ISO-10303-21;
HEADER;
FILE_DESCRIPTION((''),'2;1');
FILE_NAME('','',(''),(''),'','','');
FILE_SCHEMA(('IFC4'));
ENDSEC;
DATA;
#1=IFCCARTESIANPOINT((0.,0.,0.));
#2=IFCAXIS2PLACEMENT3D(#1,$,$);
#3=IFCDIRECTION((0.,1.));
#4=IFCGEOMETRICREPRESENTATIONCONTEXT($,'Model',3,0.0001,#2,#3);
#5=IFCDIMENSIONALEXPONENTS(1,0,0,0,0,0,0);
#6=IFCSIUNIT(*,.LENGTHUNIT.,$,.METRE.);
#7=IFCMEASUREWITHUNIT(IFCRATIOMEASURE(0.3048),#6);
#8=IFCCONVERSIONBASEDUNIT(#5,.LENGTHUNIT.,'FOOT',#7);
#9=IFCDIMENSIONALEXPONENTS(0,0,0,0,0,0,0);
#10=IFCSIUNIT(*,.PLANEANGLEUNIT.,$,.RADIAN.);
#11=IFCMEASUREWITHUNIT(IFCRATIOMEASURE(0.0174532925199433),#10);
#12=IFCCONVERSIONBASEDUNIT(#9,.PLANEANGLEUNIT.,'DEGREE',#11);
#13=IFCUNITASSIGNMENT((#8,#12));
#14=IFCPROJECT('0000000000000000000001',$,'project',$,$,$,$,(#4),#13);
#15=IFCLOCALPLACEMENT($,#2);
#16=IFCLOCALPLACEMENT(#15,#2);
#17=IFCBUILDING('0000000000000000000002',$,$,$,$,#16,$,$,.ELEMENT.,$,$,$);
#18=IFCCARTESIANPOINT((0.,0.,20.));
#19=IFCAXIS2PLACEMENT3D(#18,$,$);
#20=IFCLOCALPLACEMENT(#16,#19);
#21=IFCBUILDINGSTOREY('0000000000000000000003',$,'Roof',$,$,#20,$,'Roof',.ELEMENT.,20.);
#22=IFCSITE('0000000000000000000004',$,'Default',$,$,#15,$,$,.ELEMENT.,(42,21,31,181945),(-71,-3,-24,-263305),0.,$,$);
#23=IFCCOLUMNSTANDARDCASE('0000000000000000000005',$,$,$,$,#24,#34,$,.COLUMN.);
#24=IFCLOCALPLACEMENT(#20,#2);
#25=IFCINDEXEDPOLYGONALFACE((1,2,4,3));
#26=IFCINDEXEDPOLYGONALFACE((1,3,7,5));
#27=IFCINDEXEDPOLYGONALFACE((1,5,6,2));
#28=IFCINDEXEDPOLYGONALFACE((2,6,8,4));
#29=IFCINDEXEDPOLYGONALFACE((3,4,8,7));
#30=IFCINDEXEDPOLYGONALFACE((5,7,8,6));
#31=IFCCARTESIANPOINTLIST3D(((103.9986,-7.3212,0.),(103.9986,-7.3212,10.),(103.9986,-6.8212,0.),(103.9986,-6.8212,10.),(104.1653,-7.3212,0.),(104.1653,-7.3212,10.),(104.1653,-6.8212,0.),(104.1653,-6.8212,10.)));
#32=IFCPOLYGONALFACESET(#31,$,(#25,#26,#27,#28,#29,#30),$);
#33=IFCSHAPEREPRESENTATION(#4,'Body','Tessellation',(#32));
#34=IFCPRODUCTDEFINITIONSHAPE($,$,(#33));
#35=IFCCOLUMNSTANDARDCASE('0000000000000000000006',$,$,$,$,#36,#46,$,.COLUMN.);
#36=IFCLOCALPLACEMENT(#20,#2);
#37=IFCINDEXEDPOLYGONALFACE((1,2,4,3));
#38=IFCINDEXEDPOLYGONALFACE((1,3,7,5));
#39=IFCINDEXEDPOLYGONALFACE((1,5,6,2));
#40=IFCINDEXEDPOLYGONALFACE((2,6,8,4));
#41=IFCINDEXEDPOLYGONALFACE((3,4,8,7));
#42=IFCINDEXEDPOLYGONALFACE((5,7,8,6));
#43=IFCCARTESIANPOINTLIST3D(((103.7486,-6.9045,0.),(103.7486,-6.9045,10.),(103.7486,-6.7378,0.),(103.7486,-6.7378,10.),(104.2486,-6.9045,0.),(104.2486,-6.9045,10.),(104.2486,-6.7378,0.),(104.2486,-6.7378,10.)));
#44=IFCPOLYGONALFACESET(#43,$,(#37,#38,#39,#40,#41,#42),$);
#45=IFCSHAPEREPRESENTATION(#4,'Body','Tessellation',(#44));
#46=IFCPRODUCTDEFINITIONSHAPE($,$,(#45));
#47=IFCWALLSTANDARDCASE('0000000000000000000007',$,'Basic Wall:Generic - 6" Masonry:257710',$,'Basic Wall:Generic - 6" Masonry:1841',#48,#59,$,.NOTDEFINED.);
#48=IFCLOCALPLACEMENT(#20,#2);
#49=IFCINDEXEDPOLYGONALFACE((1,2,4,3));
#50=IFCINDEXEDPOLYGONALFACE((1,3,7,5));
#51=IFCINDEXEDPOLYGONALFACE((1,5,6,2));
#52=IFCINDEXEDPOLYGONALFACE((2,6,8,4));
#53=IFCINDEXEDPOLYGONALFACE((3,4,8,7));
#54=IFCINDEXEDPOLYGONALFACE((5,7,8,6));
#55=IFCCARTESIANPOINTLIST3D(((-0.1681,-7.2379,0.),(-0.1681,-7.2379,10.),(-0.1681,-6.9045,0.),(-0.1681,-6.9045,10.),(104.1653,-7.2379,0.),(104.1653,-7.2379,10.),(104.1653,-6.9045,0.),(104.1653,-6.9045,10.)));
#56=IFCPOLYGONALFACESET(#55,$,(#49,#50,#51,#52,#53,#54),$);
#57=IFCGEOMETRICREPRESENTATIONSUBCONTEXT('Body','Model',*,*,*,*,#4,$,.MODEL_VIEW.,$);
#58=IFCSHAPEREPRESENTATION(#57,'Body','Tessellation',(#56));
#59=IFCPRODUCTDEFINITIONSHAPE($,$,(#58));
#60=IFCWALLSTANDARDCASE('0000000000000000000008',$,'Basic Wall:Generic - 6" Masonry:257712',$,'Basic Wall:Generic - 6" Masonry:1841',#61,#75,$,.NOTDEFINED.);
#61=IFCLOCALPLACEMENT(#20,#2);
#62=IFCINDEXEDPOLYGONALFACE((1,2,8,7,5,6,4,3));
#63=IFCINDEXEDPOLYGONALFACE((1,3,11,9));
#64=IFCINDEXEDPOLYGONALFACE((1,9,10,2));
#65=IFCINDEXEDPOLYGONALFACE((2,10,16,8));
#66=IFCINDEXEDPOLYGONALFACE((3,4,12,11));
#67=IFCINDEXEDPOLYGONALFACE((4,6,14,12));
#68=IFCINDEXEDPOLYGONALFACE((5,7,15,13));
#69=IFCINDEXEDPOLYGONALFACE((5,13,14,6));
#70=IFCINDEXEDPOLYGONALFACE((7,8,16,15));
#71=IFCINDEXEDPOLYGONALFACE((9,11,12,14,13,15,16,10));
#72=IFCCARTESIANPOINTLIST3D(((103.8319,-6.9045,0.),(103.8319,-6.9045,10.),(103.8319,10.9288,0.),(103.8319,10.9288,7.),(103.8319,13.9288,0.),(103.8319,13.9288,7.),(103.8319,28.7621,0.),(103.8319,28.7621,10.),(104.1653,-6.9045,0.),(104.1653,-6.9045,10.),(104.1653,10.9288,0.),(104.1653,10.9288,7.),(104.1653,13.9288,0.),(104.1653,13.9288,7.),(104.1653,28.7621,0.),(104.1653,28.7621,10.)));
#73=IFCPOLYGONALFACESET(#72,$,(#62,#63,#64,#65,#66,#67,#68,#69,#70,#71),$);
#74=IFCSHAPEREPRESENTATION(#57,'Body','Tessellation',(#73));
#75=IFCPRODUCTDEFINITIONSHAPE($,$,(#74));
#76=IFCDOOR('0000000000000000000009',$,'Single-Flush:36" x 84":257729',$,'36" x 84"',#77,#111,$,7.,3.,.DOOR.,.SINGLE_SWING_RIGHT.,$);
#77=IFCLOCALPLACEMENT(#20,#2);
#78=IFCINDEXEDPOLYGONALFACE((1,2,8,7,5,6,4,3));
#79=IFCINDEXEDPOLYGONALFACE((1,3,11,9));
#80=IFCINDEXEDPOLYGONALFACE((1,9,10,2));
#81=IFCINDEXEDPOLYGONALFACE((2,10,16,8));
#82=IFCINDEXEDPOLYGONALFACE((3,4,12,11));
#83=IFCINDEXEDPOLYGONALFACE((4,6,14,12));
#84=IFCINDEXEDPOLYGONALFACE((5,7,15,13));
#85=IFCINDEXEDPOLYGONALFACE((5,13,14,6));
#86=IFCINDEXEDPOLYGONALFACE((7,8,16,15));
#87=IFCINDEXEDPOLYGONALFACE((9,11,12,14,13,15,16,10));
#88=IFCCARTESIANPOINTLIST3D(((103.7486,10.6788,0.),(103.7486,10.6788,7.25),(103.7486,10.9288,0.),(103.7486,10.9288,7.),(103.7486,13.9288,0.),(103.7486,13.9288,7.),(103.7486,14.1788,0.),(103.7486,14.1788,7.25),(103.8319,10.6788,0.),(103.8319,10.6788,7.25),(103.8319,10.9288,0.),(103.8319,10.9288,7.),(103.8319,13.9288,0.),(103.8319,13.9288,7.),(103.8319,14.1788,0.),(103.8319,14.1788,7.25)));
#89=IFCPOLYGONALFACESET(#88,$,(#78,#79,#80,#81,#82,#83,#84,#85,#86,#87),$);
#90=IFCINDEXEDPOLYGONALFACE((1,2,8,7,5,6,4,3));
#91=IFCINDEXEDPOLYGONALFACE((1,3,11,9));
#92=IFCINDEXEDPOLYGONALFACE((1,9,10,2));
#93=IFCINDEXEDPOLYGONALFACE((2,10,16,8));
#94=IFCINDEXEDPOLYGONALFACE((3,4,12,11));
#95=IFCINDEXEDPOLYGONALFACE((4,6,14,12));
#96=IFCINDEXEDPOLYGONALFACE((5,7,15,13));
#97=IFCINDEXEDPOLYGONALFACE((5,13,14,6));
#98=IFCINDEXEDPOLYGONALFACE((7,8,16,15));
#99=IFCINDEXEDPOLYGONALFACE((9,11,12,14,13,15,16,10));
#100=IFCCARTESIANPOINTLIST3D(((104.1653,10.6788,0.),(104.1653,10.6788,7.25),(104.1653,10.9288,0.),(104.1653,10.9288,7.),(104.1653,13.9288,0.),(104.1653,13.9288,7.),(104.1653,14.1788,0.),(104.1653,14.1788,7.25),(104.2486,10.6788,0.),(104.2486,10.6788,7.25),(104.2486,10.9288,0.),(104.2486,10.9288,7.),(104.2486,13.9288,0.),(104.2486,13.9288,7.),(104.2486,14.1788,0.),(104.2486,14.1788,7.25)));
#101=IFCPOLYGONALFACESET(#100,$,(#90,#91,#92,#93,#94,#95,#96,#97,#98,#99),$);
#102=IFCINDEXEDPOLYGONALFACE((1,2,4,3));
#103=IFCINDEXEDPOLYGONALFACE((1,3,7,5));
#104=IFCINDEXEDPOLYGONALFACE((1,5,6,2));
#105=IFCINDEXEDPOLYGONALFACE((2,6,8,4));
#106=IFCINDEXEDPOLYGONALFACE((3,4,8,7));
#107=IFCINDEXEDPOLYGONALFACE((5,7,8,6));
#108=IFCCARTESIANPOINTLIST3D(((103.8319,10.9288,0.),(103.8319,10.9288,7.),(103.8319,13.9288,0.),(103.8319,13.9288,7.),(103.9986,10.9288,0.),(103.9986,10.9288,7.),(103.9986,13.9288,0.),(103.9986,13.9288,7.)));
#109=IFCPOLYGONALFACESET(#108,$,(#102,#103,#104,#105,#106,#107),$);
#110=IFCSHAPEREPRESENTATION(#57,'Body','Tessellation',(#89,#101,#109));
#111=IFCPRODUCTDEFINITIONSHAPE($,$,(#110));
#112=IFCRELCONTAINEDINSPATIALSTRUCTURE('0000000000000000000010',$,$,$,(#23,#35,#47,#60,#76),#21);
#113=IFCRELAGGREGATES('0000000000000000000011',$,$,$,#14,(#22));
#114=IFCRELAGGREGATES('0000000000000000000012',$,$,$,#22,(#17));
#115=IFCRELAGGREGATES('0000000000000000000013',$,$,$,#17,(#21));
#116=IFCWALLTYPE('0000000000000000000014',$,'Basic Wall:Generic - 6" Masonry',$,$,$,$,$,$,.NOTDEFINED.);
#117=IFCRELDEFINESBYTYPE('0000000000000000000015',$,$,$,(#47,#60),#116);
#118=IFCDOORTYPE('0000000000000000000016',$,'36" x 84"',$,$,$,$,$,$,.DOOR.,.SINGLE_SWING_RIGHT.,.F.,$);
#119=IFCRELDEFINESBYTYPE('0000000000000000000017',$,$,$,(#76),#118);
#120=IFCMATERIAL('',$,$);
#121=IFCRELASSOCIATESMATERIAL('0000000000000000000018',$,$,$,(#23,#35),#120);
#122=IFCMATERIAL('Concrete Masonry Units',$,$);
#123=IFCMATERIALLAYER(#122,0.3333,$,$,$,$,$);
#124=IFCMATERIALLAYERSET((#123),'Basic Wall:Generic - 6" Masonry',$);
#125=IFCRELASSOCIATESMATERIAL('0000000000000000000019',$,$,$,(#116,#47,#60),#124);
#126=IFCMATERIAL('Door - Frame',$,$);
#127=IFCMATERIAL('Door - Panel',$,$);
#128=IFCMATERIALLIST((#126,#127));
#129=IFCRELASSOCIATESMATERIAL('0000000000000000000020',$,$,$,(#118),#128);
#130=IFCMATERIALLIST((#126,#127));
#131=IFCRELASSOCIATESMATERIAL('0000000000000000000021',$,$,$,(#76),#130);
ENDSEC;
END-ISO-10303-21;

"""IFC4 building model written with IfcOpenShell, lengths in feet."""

from ifc_helpers import new_model, entity, si_unit, converted_unit, direction, frame, frame_2d, origin, place, context, subcontext, project, spatial, polyline, rectangle, outline, extrude, source, transform, mapped, material, material_list, layer, layer_set, layer_usage, type_object, type_shapes, element, fill, save


model = new_model("IFC4")

# Units and contexts
model_context = context("Model", 3, precision=0.0001, world=origin(), true_north=direction((0.0, 1.0)))
body_context = subcontext(model_context, "Body", "Model", "MODEL_VIEW")
ifc_project = project(units=[converted_unit("LENGTHUNIT", "FOOT", entity("IfcRatioMeasure", 0.3048), si_unit("LENGTHUNIT", "METRE"), dimensions=[1, 0, 0, 0, 0, 0, 0]), converted_unit("PLANEANGLEUNIT", "DEGREE", entity("IfcRatioMeasure", 0.0174532925199433), si_unit("PLANEANGLEUNIT", "RADIAN"), dimensions=[0, 0, 0, 0, 0, 0, 0])], contexts=[model_context])

# Site, building, storey
site_placement = place(None, origin())
site = spatial("IfcSite", under=ifc_project, at=site_placement, Name="Default", CompositionType="ELEMENT", RefLatitude=(42, 21, 31, 181945), RefLongitude=(-71, -3, -24, -263305), RefElevation=0.0)
building_placement = place(site_placement, origin())
building = spatial("IfcBuilding", under=site, at=building_placement, CompositionType="ELEMENT")
storey_placement = place(building_placement, frame((0.0, 0.0, 20.0)))
storey = spatial("IfcBuildingStorey", under=building, at=storey_placement, Name="Roof", LongName="Roof", CompositionType="ELEMENT", Elevation=20.0)

# Columns
ifc_material_1 = material(Name="")
wall_1_placement = place(storey_placement, frame((104.1653, -7.0712, 0.0), z_axis=(0.0, 0.0, 1.0), x_axis=(-1.0, 0.0, 0.0)))
for number, where, z_axis, x_axis in (
    (1, (0.0833, 0.0, 0.0), (0.0, 0.0, 1.0), (1.0, 0.0, 0.0)),
):
    element("IfcColumnStandardCase", number, at=place(wall_1_placement, frame(where, z_axis=z_axis, x_axis=x_axis)), inside=storey, material=ifc_material_1, PredefinedType="COLUMN", context=model_context, shape_type="SweptSolid", body=[
        extrude(rectangle(XDim=0.1667, YDim=0.5), origin(), (0.0, 0.0, 1.0), 10.0),
    ])
wall_2_placement = place(storey_placement, frame((103.9986, -6.9045, 0.0), z_axis=(0.0, 0.0, 1.0), x_axis=(0.0, 1.0, 0.0)))
for number, where, z_axis, x_axis in (
    (2, (0.0833, 0.0, 0.0), (0.0, 0.0, 1.0), (1.0, 0.0, 0.0)),
):
    element("IfcColumnStandardCase", number, at=place(wall_2_placement, frame(where, z_axis=z_axis, x_axis=x_axis)), inside=storey, material=ifc_material_1, PredefinedType="COLUMN", context=model_context, shape_type="SweptSolid", body=[
        extrude(rectangle(XDim=0.1667, YDim=0.5), origin(), (0.0, 0.0, 1.0), 10.0),
    ])

# Wall
ifc_material_2 = material(Name="Concrete Masonry Units")
ifc_layer = layer(ifc_material_2, 0.3333)
ifc_layer_set = layer_set([ifc_layer], Name="Basic Wall:Generic - 6\" Masonry")
ifc_layer_usage_1 = layer_usage(ifc_layer_set, "AXIS2", "NEGATIVE", 0.1667)
wall_type = type_object("IfcWallType", Name="Basic Wall:Generic - 6\" Masonry", PredefinedType="NOTDEFINED", material=ifc_layer_set)
element("IfcWallStandardCase", 3, at=wall_1_placement, inside=storey, type_object=wall_type, material=ifc_layer_usage_1, Name="Basic Wall:Generic - 6\" Masonry:257710", ObjectType="Basic Wall:Generic - 6\" Masonry:1841", PredefinedType="NOTDEFINED", context=body_context, shape_type="SweptSolid", body=[
    extrude(rectangle(XDim=104.3333, YDim=0.3333, at=frame_2d((52.1667, 0.0), x_axis=(-1.0, 0.0))), origin(), (0.0, 0.0, 1.0), 10.0),
])

# Wall, opening, door
ifc_layer_usage_2 = layer_usage(ifc_layer_set, "AXIS2", "NEGATIVE", 0.1667)
wall_2 = element("IfcWallStandardCase", 4, at=wall_2_placement, inside=storey, type_object=wall_type, material=ifc_layer_usage_2, Name="Basic Wall:Generic - 6\" Masonry:257712", ObjectType="Basic Wall:Generic - 6\" Masonry:1841", PredefinedType="NOTDEFINED", context=body_context, shape_type="SweptSolid", body=[
    extrude(rectangle(XDim=35.6667, YDim=0.3333, at=frame_2d((17.8333, 0.0), x_axis=(-1.0, 0.0))), origin(), (0.0, 0.0, 1.0), 10.0),
])
opening_placement = place(wall_2_placement, frame((17.8333, -0.1667, 0.0)))
opening = element("IfcOpeningElement", 5, at=opening_placement, cuts=wall_2, ObjectType="Opening", PredefinedType="OPENING", context=body_context, shape_type="SweptSolid", body=[
    extrude(rectangle(XDim=3.0, YDim=7.0, at=frame_2d((3.5, 1.5), x_axis=(0.0, 1.0))), frame((0.0, 0.0, 0.0), z_axis=(0.0, 1.0, 0.0), x_axis=(0.0, 0.0, 1.0)), (0.0, 0.0, 1.0), 0.3333),
])
ifc_material_3 = material(Name="Door - Frame")
ifc_material_4 = material(Name="Door - Panel")
ifc_material_list_1 = material_list([ifc_material_3, ifc_material_4])
ifc_material_list_2 = material_list([ifc_material_3, ifc_material_4])
door_type = type_object("IfcDoorType", Name="36\" x 84\"", OperationType="SINGLE_SWING_RIGHT", ParameterTakesPrecedence=False, PredefinedType="DOOR", material=ifc_material_list_2)
shared_shape = source(origin(), body_context, "Body", "SweptSolid", [
    extrude(outline(polyline([(-1.75, -3.6875), (1.75, -3.6875), (1.75, 3.5625), (1.5, 3.5625), (1.5, -3.4375), (-1.5, -3.4375), (-1.5, 3.5625), (-1.75, 3.5625), (-1.75, -3.6875)])), frame((1.5, 0.3333, 3.5625), z_axis=(0.0, 1.0, 0.0), x_axis=(1.0, 0.0, 0.0)), (0.0, 0.0, 1.0), 0.0833),
    extrude(outline(polyline([(-3.6875, -1.75), (3.5625, -1.75), (3.5625, -1.5), (-3.4375, -1.5), (-3.4375, 1.5), (3.5625, 1.5), (3.5625, 1.75), (-3.6875, 1.75), (-3.6875, -1.75)])), frame((1.5, -0.0833, 3.5625), z_axis=(0.0, 1.0, 0.0), x_axis=(0.0, 0.0, -1.0)), (0.0, 0.0, 1.0), 0.0833),
    extrude(rectangle(XDim=0.1667, YDim=3.0, at=frame_2d((0.0, 0.0), x_axis=(1.0, 0.0))), frame((1.5, 0.25, 0.0), z_axis=(0.0, 0.0, 1.0), x_axis=(0.0, 1.0, 0.0)), (0.0, 0.0, 1.0), 7.0),
])
type_shapes(door_type, [shared_shape])
door_placement = place(opening_placement, origin())
door = element("IfcDoor", 6, at=door_placement, inside=storey, type_object=door_type, material=ifc_material_list_1, Name="Single-Flush:36\" x 84\":257729", ObjectType="36\" x 84\"", OperationType="SINGLE_SWING_RIGHT", OverallHeight=7.0, OverallWidth=3.0, PredefinedType="DOOR", context=body_context, shape_type="MappedRepresentation", body=[
    mapped(shared_shape, transform((0.0, 0.0, 0.0), scale=1.0)),
])
fill(opening, door)

save(model, "model.ifc")
